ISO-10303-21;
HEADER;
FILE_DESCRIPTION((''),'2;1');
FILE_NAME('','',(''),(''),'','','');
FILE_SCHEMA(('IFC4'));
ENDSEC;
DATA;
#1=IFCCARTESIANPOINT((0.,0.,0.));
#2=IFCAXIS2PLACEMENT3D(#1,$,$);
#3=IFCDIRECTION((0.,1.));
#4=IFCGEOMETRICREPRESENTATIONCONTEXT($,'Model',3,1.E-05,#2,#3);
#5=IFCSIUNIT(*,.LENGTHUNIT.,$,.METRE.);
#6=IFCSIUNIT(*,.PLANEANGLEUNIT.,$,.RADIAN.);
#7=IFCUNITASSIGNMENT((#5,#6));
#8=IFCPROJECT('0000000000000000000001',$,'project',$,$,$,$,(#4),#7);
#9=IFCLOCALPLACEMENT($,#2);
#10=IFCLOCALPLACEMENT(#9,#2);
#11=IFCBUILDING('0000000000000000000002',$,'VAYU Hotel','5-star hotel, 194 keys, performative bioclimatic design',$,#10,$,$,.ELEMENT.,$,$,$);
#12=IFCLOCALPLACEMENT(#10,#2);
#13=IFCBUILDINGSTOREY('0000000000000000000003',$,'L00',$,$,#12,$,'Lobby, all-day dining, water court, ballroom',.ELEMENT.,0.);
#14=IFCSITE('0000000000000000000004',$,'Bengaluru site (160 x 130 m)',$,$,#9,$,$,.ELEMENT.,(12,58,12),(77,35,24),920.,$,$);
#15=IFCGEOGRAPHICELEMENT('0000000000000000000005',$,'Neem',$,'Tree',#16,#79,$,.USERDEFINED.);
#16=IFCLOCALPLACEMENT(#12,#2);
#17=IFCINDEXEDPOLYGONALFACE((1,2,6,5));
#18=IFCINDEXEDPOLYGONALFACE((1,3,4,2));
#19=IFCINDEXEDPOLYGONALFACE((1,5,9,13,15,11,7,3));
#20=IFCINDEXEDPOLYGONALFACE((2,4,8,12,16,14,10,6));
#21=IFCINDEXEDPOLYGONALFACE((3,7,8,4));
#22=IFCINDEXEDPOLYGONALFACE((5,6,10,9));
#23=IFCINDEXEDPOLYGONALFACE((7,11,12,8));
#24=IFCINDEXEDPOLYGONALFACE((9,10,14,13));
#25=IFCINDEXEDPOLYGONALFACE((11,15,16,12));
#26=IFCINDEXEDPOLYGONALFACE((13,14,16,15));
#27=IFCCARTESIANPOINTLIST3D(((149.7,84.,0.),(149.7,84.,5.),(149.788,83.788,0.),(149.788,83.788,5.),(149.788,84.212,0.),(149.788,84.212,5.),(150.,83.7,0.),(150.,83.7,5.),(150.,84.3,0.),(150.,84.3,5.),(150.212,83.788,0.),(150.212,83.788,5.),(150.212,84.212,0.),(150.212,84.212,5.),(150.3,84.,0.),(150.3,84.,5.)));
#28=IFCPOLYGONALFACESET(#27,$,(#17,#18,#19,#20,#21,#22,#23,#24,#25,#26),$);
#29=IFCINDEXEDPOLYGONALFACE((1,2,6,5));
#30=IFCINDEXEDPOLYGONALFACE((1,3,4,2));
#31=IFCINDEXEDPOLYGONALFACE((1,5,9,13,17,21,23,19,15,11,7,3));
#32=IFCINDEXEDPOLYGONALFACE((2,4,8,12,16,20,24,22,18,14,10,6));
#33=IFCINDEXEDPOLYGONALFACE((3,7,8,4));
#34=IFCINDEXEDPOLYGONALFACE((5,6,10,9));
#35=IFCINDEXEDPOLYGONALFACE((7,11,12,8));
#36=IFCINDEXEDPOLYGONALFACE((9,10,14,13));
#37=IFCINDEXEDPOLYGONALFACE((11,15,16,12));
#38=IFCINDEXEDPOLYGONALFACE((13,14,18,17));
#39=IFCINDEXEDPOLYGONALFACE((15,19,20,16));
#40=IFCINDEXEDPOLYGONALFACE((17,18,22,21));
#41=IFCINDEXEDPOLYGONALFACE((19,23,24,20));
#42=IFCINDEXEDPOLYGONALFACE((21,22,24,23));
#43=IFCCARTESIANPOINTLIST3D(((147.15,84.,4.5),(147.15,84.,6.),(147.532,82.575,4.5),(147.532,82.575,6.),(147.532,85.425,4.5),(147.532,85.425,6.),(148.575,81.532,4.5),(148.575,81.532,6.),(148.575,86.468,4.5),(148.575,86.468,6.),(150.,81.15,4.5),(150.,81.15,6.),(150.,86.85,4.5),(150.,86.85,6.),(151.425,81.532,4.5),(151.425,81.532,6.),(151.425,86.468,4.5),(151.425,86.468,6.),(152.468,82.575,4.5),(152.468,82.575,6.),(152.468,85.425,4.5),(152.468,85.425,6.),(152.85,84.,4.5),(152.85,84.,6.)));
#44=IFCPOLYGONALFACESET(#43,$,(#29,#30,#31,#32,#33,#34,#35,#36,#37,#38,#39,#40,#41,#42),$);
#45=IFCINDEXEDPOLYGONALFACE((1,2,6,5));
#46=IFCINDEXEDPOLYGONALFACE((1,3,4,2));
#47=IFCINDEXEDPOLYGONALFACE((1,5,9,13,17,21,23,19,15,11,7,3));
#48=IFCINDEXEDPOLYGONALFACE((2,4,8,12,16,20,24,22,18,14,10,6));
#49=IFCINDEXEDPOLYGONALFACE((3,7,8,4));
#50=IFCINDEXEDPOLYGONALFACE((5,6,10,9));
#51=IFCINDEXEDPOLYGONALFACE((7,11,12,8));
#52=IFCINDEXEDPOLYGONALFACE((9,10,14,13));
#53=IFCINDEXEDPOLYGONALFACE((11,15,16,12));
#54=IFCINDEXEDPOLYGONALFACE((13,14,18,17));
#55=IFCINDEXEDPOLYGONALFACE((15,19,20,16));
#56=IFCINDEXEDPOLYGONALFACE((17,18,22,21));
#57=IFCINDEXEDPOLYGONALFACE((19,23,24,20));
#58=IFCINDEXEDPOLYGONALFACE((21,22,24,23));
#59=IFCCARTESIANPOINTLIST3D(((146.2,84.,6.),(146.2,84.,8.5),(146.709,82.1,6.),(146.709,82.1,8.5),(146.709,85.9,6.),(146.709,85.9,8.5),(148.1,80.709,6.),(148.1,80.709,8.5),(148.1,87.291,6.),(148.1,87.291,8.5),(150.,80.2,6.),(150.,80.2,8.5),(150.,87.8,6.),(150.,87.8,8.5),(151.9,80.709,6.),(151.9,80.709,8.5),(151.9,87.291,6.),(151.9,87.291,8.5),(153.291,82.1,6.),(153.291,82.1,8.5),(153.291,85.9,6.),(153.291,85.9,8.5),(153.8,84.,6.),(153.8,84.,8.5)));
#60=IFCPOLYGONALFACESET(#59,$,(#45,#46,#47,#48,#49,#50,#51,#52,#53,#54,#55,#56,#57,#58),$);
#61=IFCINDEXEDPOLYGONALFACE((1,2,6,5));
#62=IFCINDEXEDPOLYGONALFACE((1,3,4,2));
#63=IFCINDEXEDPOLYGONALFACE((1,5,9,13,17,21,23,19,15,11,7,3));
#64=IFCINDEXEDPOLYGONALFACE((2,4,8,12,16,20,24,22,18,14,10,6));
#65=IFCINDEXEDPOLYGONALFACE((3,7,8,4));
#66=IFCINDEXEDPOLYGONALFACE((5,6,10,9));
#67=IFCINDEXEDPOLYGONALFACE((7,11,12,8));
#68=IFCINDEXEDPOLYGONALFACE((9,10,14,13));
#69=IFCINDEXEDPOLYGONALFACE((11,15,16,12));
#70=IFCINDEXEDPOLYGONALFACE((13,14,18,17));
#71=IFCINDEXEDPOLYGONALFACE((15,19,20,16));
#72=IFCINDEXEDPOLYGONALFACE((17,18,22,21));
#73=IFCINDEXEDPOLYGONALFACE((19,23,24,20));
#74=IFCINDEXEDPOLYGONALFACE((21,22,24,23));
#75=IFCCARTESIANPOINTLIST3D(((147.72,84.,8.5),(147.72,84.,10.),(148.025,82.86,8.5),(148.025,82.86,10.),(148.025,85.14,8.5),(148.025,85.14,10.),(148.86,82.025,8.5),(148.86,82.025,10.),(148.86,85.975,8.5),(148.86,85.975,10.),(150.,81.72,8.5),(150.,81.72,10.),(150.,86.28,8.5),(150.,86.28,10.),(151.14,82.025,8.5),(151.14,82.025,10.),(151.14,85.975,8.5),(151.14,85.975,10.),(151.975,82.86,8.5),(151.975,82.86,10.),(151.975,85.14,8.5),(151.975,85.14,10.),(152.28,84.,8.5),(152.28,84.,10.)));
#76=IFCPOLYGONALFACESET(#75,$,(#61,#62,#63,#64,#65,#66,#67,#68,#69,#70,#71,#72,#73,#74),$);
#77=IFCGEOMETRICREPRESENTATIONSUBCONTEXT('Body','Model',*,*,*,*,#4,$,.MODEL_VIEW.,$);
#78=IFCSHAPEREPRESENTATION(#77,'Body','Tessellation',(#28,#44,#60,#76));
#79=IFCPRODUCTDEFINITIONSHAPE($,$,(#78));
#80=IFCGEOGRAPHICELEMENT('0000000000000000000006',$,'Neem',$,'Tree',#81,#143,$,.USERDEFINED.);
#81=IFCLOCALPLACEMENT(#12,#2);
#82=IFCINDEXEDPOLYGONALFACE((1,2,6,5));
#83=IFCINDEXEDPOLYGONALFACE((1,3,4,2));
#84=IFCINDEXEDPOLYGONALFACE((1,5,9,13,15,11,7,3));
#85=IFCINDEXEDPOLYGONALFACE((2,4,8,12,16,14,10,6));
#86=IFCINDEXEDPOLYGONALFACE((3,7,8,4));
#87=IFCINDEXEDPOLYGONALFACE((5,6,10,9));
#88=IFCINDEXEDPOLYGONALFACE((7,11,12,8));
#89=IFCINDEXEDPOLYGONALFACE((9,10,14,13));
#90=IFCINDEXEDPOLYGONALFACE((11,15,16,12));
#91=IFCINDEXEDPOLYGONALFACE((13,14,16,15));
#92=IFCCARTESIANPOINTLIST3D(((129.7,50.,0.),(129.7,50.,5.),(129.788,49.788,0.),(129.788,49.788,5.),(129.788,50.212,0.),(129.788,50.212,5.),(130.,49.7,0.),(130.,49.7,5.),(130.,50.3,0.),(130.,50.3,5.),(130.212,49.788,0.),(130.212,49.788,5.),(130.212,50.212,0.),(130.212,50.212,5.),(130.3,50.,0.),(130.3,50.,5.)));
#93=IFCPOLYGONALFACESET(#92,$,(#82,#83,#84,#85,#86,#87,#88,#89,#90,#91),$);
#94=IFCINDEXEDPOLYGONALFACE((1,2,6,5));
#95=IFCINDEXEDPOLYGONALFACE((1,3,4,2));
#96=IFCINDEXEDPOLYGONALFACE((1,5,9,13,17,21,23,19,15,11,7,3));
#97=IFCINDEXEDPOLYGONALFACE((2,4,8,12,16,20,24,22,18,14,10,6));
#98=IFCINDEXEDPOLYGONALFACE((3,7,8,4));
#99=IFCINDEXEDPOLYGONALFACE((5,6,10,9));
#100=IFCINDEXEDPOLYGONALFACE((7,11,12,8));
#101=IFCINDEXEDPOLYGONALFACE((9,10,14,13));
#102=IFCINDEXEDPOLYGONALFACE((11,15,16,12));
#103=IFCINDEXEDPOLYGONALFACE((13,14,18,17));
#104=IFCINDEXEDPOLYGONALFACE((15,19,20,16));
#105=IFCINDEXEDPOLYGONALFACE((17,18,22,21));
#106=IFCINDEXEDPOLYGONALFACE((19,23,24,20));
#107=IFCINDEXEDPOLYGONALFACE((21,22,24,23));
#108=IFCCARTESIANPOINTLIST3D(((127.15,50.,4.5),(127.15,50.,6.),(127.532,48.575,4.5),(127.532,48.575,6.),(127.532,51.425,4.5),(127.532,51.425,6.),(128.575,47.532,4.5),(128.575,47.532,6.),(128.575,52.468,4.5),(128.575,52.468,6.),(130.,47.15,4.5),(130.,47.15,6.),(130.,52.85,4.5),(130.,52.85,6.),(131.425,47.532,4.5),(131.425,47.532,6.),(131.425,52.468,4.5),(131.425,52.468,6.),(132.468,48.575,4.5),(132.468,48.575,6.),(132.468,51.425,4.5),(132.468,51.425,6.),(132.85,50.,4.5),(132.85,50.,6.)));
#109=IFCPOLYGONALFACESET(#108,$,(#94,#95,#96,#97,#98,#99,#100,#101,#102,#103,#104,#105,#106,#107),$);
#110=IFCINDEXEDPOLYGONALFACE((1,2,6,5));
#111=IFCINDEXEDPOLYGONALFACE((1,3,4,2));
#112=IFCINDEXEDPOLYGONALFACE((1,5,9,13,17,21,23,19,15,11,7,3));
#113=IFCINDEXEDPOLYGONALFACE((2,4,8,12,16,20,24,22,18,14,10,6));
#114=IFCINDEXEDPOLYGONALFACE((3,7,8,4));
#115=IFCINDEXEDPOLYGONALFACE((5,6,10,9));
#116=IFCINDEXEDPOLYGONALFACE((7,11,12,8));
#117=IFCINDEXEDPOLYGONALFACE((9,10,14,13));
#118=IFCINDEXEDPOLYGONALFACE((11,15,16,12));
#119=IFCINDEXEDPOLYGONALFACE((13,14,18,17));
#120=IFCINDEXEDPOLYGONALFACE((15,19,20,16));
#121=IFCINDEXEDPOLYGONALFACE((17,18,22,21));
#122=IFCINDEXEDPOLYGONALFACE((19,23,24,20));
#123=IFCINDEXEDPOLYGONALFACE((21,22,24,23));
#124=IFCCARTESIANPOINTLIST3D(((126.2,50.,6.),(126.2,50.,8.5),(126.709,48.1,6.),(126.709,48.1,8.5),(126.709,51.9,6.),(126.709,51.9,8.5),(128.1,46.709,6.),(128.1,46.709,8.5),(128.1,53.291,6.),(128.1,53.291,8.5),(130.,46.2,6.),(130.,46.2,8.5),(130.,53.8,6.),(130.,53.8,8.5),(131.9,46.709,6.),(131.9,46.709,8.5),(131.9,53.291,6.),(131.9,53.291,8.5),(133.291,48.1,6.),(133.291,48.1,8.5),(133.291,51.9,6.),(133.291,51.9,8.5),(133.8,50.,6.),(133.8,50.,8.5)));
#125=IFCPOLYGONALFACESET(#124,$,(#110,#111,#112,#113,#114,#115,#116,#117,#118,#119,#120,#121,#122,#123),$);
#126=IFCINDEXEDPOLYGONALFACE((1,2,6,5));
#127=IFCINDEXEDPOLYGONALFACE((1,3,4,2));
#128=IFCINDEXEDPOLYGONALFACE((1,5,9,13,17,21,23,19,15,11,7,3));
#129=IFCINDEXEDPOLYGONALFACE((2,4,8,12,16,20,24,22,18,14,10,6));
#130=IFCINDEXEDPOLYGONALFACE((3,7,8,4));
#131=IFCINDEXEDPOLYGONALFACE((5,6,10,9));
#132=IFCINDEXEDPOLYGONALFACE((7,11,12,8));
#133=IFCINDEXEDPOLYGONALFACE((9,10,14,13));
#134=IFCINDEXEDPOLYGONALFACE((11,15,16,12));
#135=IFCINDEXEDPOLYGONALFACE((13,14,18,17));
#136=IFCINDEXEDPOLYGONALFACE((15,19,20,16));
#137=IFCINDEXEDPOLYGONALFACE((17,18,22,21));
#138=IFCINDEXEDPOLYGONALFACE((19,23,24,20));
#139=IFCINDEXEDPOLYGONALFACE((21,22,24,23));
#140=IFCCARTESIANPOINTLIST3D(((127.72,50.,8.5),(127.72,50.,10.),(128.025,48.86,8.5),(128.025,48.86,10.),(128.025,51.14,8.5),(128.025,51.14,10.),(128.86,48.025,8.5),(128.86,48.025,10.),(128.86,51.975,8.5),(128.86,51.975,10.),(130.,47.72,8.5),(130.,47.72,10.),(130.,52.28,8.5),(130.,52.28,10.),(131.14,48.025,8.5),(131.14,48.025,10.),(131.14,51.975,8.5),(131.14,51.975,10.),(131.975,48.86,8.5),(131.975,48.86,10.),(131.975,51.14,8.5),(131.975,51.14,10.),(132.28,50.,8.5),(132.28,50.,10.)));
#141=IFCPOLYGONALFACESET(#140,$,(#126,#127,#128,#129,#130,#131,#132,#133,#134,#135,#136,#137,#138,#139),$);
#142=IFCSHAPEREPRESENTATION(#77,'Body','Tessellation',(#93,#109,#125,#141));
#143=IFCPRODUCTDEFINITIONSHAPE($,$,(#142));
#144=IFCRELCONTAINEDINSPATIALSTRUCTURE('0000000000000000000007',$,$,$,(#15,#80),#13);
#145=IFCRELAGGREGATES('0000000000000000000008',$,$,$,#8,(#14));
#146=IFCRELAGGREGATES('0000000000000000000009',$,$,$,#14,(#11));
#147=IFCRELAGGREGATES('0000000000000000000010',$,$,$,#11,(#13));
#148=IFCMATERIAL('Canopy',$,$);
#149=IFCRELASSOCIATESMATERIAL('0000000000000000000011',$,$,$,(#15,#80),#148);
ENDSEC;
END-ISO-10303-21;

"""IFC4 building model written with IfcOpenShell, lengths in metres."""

from ifc_helpers import new_model, si_unit, direction, frame, origin, place, context, subcontext, project, spatial, polyline, outline, extrude, material, element, save


model = new_model("IFC4")

# Units and contexts
model_context = context("Model", 3, precision=1e-05, world=origin(), true_north=direction((0.0, 1.0)))
body_context = subcontext(model_context, "Body", "Model", "MODEL_VIEW")
ifc_project = project(units=[si_unit("LENGTHUNIT", "METRE"), si_unit("PLANEANGLEUNIT", "RADIAN")], contexts=[model_context])

# Site, building, storey
site_placement = place(None, origin())
site = spatial("IfcSite", under=ifc_project, at=site_placement, Name="Bengaluru site (160 x 130 m)", CompositionType="ELEMENT", RefLatitude=(12, 58, 12), RefLongitude=(77, 35, 24), RefElevation=920.0)
building_placement = place(site_placement, origin())
building = spatial("IfcBuilding", under=site, at=building_placement, Name="VAYU Hotel", Description="5-star hotel, 194 keys, performative bioclimatic design", CompositionType="ELEMENT")
storey_placement = place(building_placement, origin())
storey = spatial("IfcBuildingStorey", under=building, at=storey_placement, Name="L00", LongName="Lobby, all-day dining, water court, ballroom", CompositionType="ELEMENT", Elevation=0.0)

# Geographic elements
ifc_material_1 = material(Name="Canopy")
geographic_element_1_placement = place(storey_placement, origin())
element("IfcGeographicElement", 1, at=geographic_element_1_placement, inside=storey, material=ifc_material_1, Name="Neem", ObjectType="Tree", PredefinedType="USERDEFINED", context=body_context, shape_type="SweptSolid", body=[
    extrude(outline(polyline([(150.3, 84.0), (150.212, 84.212), (150.0, 84.3), (149.788, 84.212), (149.7, 84.0), (149.788, 83.788), (150.0, 83.7), (150.212, 83.788), (150.3, 84.0)])), origin(), (0.0, 0.0, 1.0), 5.0),
    extrude(outline(polyline([(152.85, 84.0), (152.468, 85.425), (151.425, 86.468), (150.0, 86.85), (148.575, 86.468), (147.532, 85.425), (147.15, 84.0), (147.532, 82.575), (148.575, 81.532), (150.0, 81.15), (151.425, 81.532), (152.468, 82.575), (152.85, 84.0)])), frame((0.0, 0.0, 4.5)), (0.0, 0.0, 1.0), 1.5),
    extrude(outline(polyline([(153.8, 84.0), (153.291, 85.9), (151.9, 87.291), (150.0, 87.8), (148.1, 87.291), (146.709, 85.9), (146.2, 84.0), (146.709, 82.1), (148.1, 80.709), (150.0, 80.2), (151.9, 80.709), (153.291, 82.1), (153.8, 84.0)])), frame((0.0, 0.0, 6.0)), (0.0, 0.0, 1.0), 2.5),
    extrude(outline(polyline([(152.28, 84.0), (151.975, 85.14), (151.14, 85.975), (150.0, 86.28), (148.86, 85.975), (148.025, 85.14), (147.72, 84.0), (148.025, 82.86), (148.86, 82.025), (150.0, 81.72), (151.14, 82.025), (151.975, 82.86), (152.28, 84.0)])), frame((0.0, 0.0, 8.5)), (0.0, 0.0, 1.0), 1.5),
])
geographic_element_2_placement = place(storey_placement, origin())
element("IfcGeographicElement", 2, at=geographic_element_2_placement, inside=storey, material=ifc_material_1, Name="Neem", ObjectType="Tree", PredefinedType="USERDEFINED", context=body_context, shape_type="SweptSolid", body=[
    extrude(outline(polyline([(130.3, 50.0), (130.212, 50.212), (130.0, 50.3), (129.788, 50.212), (129.7, 50.0), (129.788, 49.788), (130.0, 49.7), (130.212, 49.788), (130.3, 50.0)])), origin(), (0.0, 0.0, 1.0), 5.0),
    extrude(outline(polyline([(132.85, 50.0), (132.468, 51.425), (131.425, 52.468), (130.0, 52.85), (128.575, 52.468), (127.532, 51.425), (127.15, 50.0), (127.532, 48.575), (128.575, 47.532), (130.0, 47.15), (131.425, 47.532), (132.468, 48.575), (132.85, 50.0)])), frame((0.0, 0.0, 4.5)), (0.0, 0.0, 1.0), 1.5),
    extrude(outline(polyline([(133.8, 50.0), (133.291, 51.9), (131.9, 53.291), (130.0, 53.8), (128.1, 53.291), (126.709, 51.9), (126.2, 50.0), (126.709, 48.1), (128.1, 46.709), (130.0, 46.2), (131.9, 46.709), (133.291, 48.1), (133.8, 50.0)])), frame((0.0, 0.0, 6.0)), (0.0, 0.0, 1.0), 2.5),
    extrude(outline(polyline([(132.28, 50.0), (131.975, 51.14), (131.14, 51.975), (130.0, 52.28), (128.86, 51.975), (128.025, 51.14), (127.72, 50.0), (128.025, 48.86), (128.86, 48.025), (130.0, 47.72), (131.14, 48.025), (131.975, 48.86), (132.28, 50.0)])), frame((0.0, 0.0, 8.5)), (0.0, 0.0, 1.0), 1.5),
])

save(model, "model.ifc")
